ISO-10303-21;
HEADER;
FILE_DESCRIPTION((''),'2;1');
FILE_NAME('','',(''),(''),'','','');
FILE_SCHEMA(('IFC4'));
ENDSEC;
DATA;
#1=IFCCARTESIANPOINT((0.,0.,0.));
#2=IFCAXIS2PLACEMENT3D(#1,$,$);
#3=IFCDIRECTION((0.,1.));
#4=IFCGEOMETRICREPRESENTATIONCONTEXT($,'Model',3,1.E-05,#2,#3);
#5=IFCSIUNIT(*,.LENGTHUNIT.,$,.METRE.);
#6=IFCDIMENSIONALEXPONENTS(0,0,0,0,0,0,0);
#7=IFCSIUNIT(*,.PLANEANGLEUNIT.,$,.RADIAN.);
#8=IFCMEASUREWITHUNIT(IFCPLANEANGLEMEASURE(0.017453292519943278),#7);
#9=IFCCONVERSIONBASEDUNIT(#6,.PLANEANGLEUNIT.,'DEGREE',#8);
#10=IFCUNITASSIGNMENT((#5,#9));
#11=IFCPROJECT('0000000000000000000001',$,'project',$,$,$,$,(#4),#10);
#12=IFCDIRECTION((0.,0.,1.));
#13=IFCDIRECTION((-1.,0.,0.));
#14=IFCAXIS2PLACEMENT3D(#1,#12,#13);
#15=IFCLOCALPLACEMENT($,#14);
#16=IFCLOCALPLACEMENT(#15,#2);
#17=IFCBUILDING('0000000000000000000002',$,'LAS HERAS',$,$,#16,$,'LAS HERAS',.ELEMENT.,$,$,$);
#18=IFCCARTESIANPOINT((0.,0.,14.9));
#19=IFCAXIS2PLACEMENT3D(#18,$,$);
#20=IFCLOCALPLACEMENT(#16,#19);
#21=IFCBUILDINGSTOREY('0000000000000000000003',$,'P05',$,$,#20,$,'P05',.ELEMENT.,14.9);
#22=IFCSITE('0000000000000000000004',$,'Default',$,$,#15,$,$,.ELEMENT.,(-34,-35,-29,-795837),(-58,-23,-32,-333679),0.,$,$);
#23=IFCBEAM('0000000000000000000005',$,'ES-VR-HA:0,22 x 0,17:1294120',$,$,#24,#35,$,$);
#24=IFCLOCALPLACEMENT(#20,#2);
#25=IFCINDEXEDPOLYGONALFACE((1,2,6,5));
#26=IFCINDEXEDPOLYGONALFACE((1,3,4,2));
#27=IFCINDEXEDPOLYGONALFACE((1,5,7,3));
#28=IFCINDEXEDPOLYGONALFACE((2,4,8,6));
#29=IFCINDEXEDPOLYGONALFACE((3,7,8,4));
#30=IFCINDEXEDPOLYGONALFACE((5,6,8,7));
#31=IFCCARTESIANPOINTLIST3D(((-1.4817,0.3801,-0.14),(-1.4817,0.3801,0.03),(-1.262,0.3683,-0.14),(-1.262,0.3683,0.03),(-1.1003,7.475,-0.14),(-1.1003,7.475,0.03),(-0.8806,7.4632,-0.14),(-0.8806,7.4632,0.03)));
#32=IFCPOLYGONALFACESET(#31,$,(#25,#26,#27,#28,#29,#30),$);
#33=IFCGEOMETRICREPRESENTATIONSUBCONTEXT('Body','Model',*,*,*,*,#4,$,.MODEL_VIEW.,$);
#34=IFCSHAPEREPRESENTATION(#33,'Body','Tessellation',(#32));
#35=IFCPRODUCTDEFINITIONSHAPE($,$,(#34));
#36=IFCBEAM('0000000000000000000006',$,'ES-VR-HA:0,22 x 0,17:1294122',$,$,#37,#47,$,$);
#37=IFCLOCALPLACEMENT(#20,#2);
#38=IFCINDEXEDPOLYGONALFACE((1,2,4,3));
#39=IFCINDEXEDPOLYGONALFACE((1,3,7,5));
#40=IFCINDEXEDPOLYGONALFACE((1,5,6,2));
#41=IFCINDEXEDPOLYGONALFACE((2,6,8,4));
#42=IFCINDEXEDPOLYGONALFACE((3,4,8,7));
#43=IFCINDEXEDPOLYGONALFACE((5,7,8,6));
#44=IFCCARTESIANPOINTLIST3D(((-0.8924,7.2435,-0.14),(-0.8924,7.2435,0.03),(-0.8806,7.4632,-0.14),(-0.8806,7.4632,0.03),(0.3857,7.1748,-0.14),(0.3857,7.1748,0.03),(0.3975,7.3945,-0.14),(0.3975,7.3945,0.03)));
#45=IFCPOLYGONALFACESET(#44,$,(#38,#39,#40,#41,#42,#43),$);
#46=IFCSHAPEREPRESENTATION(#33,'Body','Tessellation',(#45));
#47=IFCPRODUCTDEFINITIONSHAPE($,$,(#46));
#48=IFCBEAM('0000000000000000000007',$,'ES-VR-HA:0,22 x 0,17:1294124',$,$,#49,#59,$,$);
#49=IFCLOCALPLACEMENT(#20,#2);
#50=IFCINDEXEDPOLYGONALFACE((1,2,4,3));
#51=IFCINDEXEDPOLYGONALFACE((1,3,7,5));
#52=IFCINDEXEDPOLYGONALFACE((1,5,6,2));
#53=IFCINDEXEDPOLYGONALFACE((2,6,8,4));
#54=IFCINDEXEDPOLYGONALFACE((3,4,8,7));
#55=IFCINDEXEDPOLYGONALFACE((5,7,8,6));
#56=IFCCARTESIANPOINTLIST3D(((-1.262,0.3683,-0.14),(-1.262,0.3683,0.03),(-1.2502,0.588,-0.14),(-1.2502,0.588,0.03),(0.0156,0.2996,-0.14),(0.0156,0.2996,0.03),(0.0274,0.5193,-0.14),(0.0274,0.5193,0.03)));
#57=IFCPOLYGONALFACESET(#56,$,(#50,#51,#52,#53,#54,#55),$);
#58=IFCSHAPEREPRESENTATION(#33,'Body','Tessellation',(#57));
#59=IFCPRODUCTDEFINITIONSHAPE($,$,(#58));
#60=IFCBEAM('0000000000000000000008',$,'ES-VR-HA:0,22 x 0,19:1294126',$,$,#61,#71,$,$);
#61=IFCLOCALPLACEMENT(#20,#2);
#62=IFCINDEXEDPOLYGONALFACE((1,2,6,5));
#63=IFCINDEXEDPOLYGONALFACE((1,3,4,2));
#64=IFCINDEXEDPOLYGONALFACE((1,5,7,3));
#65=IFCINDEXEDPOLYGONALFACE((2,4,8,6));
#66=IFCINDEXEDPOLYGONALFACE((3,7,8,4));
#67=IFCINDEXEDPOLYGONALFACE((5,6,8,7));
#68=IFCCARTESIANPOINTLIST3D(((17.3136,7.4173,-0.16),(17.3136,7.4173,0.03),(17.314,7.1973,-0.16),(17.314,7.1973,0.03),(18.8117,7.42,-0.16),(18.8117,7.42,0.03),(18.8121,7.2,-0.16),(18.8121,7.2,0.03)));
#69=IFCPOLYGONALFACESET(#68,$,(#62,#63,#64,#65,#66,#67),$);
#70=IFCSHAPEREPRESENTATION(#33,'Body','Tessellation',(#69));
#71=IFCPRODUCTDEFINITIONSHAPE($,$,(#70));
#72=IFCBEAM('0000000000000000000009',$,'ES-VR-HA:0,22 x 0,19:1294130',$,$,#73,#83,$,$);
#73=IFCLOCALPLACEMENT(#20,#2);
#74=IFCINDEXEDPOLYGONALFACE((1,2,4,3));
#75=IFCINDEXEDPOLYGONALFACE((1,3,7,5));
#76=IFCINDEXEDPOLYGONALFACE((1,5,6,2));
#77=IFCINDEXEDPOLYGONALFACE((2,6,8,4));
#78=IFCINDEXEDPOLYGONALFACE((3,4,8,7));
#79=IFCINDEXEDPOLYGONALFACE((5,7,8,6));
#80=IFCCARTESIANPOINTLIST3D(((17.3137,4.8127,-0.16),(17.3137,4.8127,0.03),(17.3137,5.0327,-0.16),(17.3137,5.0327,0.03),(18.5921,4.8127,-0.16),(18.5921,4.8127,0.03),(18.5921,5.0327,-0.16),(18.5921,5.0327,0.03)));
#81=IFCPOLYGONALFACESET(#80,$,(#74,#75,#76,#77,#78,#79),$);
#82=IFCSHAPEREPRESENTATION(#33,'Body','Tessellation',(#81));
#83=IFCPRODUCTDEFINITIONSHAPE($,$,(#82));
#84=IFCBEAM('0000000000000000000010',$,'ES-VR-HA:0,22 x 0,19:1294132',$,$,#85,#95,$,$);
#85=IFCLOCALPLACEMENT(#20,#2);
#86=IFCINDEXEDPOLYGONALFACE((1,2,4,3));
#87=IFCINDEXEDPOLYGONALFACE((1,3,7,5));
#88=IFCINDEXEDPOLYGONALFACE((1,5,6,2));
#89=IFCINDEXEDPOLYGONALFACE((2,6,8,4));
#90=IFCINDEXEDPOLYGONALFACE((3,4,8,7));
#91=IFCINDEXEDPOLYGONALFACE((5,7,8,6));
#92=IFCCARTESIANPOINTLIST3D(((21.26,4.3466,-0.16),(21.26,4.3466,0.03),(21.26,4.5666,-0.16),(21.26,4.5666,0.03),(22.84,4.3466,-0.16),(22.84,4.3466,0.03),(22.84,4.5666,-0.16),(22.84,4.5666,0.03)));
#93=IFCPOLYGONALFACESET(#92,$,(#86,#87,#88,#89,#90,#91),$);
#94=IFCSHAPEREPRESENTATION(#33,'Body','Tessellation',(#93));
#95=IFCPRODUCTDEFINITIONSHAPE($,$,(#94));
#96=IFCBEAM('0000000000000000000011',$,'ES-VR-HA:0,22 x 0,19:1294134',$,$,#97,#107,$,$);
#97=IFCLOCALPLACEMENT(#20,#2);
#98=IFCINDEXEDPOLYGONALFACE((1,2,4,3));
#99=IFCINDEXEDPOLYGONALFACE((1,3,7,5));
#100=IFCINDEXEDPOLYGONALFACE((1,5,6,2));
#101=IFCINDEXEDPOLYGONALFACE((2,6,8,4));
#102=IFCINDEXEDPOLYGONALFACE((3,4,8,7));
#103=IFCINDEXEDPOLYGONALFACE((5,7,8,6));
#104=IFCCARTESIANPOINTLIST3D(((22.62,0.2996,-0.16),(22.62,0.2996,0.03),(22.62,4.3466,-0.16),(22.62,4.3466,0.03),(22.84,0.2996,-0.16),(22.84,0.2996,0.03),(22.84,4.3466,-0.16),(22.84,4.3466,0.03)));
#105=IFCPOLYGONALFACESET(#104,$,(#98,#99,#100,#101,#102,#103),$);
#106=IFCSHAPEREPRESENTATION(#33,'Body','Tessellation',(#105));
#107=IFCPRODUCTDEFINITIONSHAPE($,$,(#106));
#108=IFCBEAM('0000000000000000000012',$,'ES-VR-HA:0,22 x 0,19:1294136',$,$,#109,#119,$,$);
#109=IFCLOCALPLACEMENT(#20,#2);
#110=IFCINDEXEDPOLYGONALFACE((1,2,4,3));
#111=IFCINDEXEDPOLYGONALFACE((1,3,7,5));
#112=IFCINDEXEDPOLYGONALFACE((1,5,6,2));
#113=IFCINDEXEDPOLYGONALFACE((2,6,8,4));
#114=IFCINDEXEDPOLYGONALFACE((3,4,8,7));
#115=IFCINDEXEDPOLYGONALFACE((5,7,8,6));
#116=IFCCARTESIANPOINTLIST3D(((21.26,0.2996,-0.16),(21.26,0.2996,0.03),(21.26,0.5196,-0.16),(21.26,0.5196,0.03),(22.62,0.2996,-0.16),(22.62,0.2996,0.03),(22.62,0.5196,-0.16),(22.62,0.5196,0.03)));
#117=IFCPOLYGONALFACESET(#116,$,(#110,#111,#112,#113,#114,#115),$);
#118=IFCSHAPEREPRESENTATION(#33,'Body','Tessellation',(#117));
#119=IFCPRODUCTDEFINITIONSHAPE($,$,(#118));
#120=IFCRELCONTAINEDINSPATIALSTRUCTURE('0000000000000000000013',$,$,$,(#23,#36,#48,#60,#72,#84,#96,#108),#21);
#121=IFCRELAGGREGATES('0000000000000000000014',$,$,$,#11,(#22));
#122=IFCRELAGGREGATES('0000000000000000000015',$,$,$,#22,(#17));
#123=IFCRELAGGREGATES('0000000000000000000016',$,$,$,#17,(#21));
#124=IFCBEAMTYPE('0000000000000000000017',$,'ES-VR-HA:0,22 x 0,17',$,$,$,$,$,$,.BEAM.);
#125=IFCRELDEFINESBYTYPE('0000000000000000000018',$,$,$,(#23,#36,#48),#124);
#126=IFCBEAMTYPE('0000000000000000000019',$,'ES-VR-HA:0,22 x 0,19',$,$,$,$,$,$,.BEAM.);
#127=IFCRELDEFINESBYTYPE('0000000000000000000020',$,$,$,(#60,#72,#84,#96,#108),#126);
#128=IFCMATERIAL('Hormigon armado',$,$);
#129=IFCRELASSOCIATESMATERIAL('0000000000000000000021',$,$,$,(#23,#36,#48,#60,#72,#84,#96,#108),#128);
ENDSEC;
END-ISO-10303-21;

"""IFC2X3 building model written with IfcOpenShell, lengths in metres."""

from ifc_helpers import new_model, entity, si_unit, converted_unit, direction, frame, frame_2d, origin, place, context, subcontext, project, spatial, rectangle, extrude, material, type_object, element, save


model = new_model("IFC2X3")

# Units and contexts
model_context = context("Model", 3, precision=1e-05, world=origin(), true_north=direction((0.0, 1.0)))
body_context = subcontext(model_context, "Body", "Model", "MODEL_VIEW")
ifc_project = project(units=[si_unit("LENGTHUNIT", "METRE"), converted_unit("PLANEANGLEUNIT", "DEGREE", entity("IfcPlaneAngleMeasure", 0.017453292519943278), si_unit("PLANEANGLEUNIT", "RADIAN"), dimensions=[0, 0, 0, 0, 0, 0, 0])], contexts=[model_context])

# Site, building, storey
site_placement = place(None, frame((0.0, 0.0, 0.0), z_axis=(0.0, 0.0, 1.0), x_axis=(-1.0, 0.0, 0.0)))
site = spatial("IfcSite", under=ifc_project, at=site_placement, Name="Default", CompositionType="ELEMENT", RefLatitude=(-34, -35, -29, -795837), RefLongitude=(-58, -23, -32, -333679), RefElevation=0.0)
building_placement = place(site_placement, origin())
building = spatial("IfcBuilding", under=site, at=building_placement, Name="LAS HERAS", LongName="LAS HERAS", CompositionType="ELEMENT")
storey_placement = place(building_placement, frame((0.0, 0.0, 14.9)))
storey = spatial("IfcBuildingStorey", under=building, at=storey_placement, Name="P05", LongName="P05", CompositionType="ELEMENT", Elevation=14.9)

# Beams
ifc_material = material(Name="Hormigon armado")
beam_type_1 = type_object("IfcBeamType", Name="ES-VR-HA:0,22 x 0,17", PredefinedType="BEAM")
beam_1_placement = place(storey_placement, frame((-0.9963, 7.3593, 0.03), z_axis=(0.0, 0.0, 1.0), x_axis=(-0.05369, -0.998558, 0.0)))
element("IfcBeam", 1, at=beam_1_placement, inside=storey, type_object=beam_type_1, material=ifc_material, Name="ES-VR-HA:0,22 x 0,17:1294120", context=body_context, shape_type="SweptSolid", body=[
    extrude(rectangle(XDim=0.17, YDim=0.22, at=frame_2d((0.0, 0.0), x_axis=(1.0, 0.0))), frame((-0.11, 0.0, -0.085), z_axis=(1.0, 0.0, 0.0), x_axis=(0.0, 0.0, -1.0)), (0.0, 0.0, 1.0), 7.1052),
])
beam_2_placement = place(storey_placement, frame((0.3916, 7.2846, 0.03), z_axis=(0.0, 0.0, 1.0), x_axis=(-0.998558, 0.05368, 0.0)))
element("IfcBeam", 2, at=beam_2_placement, inside=storey, type_object=beam_type_1, material=ifc_material, Name="ES-VR-HA:0,22 x 0,17:1294122", context=body_context, shape_type="SweptSolid", body=[
    extrude(rectangle(XDim=0.17, YDim=0.22, at=frame_2d((0.0, 0.0), x_axis=(1.0, 0.0))), frame((0.0, 0.0, -0.085), z_axis=(1.0, 0.0, 0.0), x_axis=(0.0, 0.0, -1.0)), (0.0, 0.0, 1.0), 1.28),
])
beam_3_placement = place(storey_placement, frame((0.0215, 0.4094, 0.03), z_axis=(0.0, 0.0, 1.0), x_axis=(-0.998558, 0.05369, 0.0)))
element("IfcBeam", 3, at=beam_3_placement, inside=storey, type_object=beam_type_1, material=ifc_material, Name="ES-VR-HA:0,22 x 0,17:1294124", context=body_context, shape_type="SweptSolid", body=[
    extrude(rectangle(XDim=0.17, YDim=0.22, at=frame_2d((0.0, 0.0), x_axis=(1.0, 0.0))), frame((0.0, 0.0, -0.085), z_axis=(1.0, 0.0, 0.0), x_axis=(0.0, 0.0, -1.0)), (0.0, 0.0, 1.0), 1.2795),
])
beam_type_2 = type_object("IfcBeamType", Name="ES-VR-HA:0,22 x 0,19", PredefinedType="BEAM")
beam_4_placement = place(storey_placement, frame((17.3138, 7.3073, 0.03), z_axis=(0.0, 0.0, 1.0), x_axis=(0.999998, 0.001781, 0.0)))
element("IfcBeam", 4, at=beam_4_placement, inside=storey, type_object=beam_type_2, material=ifc_material, Name="ES-VR-HA:0,22 x 0,19:1294126", context=body_context, shape_type="SweptSolid", body=[
    extrude(rectangle(XDim=0.19, YDim=0.22, at=frame_2d((0.0, 0.0), x_axis=(1.0, 0.0))), frame((0.0, 0.0, -0.095), z_axis=(1.0, 0.0, 0.0), x_axis=(0.0, 0.0, -1.0)), (0.0, 0.0, 1.0), 1.4981),
])
beam_5_placement = place(storey_placement, frame((17.3137, 4.9227, 0.03)))
element("IfcBeam", 5, at=beam_5_placement, inside=storey, type_object=beam_type_2, material=ifc_material, Name="ES-VR-HA:0,22 x 0,19:1294130", context=body_context, shape_type="SweptSolid", body=[
    extrude(rectangle(XDim=0.19, YDim=0.22, at=frame_2d((0.0, 0.0), x_axis=(1.0, 0.0))), frame((0.0, 0.0, -0.095), z_axis=(1.0, 0.0, 0.0), x_axis=(0.0, 0.0, -1.0)), (0.0, 0.0, 1.0), 1.2784),
])
beam_6_placement = place(storey_placement, frame((21.26, 4.4566, 0.03)))
element("IfcBeam", 6, at=beam_6_placement, inside=storey, type_object=beam_type_2, material=ifc_material, Name="ES-VR-HA:0,22 x 0,19:1294132", context=body_context, shape_type="SweptSolid", body=[
    extrude(rectangle(XDim=0.19, YDim=0.22, at=frame_2d((0.0, 0.0), x_axis=(1.0, 0.0))), frame((0.0, 0.0, -0.095), z_axis=(1.0, 0.0, 0.0), x_axis=(0.0, 0.0, -1.0)), (0.0, 0.0, 1.0), 1.58),
])
beam_7_placement = place(storey_placement, frame((22.73, 4.4566, 0.03), z_axis=(0.0, 0.0, 1.0), x_axis=(0.0, -1.0, 0.0)))
element("IfcBeam", 7, at=beam_7_placement, inside=storey, type_object=beam_type_2, material=ifc_material, Name="ES-VR-HA:0,22 x 0,19:1294134", context=body_context, shape_type="SweptSolid", body=[
    extrude(rectangle(XDim=0.19, YDim=0.22, at=frame_2d((0.0, 0.0), x_axis=(1.0, 0.0))), frame((0.11, 0.0, -0.095), z_axis=(1.0, 0.0, 0.0), x_axis=(0.0, 0.0, -1.0)), (0.0, 0.0, 1.0), 4.0471),
])
beam_8_placement = place(storey_placement, frame((21.26, 0.4096, 0.03)))
element("IfcBeam", 8, at=beam_8_placement, inside=storey, type_object=beam_type_2, material=ifc_material, Name="ES-VR-HA:0,22 x 0,19:1294136", context=body_context, shape_type="SweptSolid", body=[
    extrude(rectangle(XDim=0.19, YDim=0.22, at=frame_2d((0.0, 0.0), x_axis=(1.0, 0.0))), frame((0.0, 0.0, -0.095), z_axis=(1.0, 0.0, 0.0), x_axis=(0.0, 0.0, -1.0)), (0.0, 0.0, 1.0), 1.36),
])

save(model, "model.ifc")
